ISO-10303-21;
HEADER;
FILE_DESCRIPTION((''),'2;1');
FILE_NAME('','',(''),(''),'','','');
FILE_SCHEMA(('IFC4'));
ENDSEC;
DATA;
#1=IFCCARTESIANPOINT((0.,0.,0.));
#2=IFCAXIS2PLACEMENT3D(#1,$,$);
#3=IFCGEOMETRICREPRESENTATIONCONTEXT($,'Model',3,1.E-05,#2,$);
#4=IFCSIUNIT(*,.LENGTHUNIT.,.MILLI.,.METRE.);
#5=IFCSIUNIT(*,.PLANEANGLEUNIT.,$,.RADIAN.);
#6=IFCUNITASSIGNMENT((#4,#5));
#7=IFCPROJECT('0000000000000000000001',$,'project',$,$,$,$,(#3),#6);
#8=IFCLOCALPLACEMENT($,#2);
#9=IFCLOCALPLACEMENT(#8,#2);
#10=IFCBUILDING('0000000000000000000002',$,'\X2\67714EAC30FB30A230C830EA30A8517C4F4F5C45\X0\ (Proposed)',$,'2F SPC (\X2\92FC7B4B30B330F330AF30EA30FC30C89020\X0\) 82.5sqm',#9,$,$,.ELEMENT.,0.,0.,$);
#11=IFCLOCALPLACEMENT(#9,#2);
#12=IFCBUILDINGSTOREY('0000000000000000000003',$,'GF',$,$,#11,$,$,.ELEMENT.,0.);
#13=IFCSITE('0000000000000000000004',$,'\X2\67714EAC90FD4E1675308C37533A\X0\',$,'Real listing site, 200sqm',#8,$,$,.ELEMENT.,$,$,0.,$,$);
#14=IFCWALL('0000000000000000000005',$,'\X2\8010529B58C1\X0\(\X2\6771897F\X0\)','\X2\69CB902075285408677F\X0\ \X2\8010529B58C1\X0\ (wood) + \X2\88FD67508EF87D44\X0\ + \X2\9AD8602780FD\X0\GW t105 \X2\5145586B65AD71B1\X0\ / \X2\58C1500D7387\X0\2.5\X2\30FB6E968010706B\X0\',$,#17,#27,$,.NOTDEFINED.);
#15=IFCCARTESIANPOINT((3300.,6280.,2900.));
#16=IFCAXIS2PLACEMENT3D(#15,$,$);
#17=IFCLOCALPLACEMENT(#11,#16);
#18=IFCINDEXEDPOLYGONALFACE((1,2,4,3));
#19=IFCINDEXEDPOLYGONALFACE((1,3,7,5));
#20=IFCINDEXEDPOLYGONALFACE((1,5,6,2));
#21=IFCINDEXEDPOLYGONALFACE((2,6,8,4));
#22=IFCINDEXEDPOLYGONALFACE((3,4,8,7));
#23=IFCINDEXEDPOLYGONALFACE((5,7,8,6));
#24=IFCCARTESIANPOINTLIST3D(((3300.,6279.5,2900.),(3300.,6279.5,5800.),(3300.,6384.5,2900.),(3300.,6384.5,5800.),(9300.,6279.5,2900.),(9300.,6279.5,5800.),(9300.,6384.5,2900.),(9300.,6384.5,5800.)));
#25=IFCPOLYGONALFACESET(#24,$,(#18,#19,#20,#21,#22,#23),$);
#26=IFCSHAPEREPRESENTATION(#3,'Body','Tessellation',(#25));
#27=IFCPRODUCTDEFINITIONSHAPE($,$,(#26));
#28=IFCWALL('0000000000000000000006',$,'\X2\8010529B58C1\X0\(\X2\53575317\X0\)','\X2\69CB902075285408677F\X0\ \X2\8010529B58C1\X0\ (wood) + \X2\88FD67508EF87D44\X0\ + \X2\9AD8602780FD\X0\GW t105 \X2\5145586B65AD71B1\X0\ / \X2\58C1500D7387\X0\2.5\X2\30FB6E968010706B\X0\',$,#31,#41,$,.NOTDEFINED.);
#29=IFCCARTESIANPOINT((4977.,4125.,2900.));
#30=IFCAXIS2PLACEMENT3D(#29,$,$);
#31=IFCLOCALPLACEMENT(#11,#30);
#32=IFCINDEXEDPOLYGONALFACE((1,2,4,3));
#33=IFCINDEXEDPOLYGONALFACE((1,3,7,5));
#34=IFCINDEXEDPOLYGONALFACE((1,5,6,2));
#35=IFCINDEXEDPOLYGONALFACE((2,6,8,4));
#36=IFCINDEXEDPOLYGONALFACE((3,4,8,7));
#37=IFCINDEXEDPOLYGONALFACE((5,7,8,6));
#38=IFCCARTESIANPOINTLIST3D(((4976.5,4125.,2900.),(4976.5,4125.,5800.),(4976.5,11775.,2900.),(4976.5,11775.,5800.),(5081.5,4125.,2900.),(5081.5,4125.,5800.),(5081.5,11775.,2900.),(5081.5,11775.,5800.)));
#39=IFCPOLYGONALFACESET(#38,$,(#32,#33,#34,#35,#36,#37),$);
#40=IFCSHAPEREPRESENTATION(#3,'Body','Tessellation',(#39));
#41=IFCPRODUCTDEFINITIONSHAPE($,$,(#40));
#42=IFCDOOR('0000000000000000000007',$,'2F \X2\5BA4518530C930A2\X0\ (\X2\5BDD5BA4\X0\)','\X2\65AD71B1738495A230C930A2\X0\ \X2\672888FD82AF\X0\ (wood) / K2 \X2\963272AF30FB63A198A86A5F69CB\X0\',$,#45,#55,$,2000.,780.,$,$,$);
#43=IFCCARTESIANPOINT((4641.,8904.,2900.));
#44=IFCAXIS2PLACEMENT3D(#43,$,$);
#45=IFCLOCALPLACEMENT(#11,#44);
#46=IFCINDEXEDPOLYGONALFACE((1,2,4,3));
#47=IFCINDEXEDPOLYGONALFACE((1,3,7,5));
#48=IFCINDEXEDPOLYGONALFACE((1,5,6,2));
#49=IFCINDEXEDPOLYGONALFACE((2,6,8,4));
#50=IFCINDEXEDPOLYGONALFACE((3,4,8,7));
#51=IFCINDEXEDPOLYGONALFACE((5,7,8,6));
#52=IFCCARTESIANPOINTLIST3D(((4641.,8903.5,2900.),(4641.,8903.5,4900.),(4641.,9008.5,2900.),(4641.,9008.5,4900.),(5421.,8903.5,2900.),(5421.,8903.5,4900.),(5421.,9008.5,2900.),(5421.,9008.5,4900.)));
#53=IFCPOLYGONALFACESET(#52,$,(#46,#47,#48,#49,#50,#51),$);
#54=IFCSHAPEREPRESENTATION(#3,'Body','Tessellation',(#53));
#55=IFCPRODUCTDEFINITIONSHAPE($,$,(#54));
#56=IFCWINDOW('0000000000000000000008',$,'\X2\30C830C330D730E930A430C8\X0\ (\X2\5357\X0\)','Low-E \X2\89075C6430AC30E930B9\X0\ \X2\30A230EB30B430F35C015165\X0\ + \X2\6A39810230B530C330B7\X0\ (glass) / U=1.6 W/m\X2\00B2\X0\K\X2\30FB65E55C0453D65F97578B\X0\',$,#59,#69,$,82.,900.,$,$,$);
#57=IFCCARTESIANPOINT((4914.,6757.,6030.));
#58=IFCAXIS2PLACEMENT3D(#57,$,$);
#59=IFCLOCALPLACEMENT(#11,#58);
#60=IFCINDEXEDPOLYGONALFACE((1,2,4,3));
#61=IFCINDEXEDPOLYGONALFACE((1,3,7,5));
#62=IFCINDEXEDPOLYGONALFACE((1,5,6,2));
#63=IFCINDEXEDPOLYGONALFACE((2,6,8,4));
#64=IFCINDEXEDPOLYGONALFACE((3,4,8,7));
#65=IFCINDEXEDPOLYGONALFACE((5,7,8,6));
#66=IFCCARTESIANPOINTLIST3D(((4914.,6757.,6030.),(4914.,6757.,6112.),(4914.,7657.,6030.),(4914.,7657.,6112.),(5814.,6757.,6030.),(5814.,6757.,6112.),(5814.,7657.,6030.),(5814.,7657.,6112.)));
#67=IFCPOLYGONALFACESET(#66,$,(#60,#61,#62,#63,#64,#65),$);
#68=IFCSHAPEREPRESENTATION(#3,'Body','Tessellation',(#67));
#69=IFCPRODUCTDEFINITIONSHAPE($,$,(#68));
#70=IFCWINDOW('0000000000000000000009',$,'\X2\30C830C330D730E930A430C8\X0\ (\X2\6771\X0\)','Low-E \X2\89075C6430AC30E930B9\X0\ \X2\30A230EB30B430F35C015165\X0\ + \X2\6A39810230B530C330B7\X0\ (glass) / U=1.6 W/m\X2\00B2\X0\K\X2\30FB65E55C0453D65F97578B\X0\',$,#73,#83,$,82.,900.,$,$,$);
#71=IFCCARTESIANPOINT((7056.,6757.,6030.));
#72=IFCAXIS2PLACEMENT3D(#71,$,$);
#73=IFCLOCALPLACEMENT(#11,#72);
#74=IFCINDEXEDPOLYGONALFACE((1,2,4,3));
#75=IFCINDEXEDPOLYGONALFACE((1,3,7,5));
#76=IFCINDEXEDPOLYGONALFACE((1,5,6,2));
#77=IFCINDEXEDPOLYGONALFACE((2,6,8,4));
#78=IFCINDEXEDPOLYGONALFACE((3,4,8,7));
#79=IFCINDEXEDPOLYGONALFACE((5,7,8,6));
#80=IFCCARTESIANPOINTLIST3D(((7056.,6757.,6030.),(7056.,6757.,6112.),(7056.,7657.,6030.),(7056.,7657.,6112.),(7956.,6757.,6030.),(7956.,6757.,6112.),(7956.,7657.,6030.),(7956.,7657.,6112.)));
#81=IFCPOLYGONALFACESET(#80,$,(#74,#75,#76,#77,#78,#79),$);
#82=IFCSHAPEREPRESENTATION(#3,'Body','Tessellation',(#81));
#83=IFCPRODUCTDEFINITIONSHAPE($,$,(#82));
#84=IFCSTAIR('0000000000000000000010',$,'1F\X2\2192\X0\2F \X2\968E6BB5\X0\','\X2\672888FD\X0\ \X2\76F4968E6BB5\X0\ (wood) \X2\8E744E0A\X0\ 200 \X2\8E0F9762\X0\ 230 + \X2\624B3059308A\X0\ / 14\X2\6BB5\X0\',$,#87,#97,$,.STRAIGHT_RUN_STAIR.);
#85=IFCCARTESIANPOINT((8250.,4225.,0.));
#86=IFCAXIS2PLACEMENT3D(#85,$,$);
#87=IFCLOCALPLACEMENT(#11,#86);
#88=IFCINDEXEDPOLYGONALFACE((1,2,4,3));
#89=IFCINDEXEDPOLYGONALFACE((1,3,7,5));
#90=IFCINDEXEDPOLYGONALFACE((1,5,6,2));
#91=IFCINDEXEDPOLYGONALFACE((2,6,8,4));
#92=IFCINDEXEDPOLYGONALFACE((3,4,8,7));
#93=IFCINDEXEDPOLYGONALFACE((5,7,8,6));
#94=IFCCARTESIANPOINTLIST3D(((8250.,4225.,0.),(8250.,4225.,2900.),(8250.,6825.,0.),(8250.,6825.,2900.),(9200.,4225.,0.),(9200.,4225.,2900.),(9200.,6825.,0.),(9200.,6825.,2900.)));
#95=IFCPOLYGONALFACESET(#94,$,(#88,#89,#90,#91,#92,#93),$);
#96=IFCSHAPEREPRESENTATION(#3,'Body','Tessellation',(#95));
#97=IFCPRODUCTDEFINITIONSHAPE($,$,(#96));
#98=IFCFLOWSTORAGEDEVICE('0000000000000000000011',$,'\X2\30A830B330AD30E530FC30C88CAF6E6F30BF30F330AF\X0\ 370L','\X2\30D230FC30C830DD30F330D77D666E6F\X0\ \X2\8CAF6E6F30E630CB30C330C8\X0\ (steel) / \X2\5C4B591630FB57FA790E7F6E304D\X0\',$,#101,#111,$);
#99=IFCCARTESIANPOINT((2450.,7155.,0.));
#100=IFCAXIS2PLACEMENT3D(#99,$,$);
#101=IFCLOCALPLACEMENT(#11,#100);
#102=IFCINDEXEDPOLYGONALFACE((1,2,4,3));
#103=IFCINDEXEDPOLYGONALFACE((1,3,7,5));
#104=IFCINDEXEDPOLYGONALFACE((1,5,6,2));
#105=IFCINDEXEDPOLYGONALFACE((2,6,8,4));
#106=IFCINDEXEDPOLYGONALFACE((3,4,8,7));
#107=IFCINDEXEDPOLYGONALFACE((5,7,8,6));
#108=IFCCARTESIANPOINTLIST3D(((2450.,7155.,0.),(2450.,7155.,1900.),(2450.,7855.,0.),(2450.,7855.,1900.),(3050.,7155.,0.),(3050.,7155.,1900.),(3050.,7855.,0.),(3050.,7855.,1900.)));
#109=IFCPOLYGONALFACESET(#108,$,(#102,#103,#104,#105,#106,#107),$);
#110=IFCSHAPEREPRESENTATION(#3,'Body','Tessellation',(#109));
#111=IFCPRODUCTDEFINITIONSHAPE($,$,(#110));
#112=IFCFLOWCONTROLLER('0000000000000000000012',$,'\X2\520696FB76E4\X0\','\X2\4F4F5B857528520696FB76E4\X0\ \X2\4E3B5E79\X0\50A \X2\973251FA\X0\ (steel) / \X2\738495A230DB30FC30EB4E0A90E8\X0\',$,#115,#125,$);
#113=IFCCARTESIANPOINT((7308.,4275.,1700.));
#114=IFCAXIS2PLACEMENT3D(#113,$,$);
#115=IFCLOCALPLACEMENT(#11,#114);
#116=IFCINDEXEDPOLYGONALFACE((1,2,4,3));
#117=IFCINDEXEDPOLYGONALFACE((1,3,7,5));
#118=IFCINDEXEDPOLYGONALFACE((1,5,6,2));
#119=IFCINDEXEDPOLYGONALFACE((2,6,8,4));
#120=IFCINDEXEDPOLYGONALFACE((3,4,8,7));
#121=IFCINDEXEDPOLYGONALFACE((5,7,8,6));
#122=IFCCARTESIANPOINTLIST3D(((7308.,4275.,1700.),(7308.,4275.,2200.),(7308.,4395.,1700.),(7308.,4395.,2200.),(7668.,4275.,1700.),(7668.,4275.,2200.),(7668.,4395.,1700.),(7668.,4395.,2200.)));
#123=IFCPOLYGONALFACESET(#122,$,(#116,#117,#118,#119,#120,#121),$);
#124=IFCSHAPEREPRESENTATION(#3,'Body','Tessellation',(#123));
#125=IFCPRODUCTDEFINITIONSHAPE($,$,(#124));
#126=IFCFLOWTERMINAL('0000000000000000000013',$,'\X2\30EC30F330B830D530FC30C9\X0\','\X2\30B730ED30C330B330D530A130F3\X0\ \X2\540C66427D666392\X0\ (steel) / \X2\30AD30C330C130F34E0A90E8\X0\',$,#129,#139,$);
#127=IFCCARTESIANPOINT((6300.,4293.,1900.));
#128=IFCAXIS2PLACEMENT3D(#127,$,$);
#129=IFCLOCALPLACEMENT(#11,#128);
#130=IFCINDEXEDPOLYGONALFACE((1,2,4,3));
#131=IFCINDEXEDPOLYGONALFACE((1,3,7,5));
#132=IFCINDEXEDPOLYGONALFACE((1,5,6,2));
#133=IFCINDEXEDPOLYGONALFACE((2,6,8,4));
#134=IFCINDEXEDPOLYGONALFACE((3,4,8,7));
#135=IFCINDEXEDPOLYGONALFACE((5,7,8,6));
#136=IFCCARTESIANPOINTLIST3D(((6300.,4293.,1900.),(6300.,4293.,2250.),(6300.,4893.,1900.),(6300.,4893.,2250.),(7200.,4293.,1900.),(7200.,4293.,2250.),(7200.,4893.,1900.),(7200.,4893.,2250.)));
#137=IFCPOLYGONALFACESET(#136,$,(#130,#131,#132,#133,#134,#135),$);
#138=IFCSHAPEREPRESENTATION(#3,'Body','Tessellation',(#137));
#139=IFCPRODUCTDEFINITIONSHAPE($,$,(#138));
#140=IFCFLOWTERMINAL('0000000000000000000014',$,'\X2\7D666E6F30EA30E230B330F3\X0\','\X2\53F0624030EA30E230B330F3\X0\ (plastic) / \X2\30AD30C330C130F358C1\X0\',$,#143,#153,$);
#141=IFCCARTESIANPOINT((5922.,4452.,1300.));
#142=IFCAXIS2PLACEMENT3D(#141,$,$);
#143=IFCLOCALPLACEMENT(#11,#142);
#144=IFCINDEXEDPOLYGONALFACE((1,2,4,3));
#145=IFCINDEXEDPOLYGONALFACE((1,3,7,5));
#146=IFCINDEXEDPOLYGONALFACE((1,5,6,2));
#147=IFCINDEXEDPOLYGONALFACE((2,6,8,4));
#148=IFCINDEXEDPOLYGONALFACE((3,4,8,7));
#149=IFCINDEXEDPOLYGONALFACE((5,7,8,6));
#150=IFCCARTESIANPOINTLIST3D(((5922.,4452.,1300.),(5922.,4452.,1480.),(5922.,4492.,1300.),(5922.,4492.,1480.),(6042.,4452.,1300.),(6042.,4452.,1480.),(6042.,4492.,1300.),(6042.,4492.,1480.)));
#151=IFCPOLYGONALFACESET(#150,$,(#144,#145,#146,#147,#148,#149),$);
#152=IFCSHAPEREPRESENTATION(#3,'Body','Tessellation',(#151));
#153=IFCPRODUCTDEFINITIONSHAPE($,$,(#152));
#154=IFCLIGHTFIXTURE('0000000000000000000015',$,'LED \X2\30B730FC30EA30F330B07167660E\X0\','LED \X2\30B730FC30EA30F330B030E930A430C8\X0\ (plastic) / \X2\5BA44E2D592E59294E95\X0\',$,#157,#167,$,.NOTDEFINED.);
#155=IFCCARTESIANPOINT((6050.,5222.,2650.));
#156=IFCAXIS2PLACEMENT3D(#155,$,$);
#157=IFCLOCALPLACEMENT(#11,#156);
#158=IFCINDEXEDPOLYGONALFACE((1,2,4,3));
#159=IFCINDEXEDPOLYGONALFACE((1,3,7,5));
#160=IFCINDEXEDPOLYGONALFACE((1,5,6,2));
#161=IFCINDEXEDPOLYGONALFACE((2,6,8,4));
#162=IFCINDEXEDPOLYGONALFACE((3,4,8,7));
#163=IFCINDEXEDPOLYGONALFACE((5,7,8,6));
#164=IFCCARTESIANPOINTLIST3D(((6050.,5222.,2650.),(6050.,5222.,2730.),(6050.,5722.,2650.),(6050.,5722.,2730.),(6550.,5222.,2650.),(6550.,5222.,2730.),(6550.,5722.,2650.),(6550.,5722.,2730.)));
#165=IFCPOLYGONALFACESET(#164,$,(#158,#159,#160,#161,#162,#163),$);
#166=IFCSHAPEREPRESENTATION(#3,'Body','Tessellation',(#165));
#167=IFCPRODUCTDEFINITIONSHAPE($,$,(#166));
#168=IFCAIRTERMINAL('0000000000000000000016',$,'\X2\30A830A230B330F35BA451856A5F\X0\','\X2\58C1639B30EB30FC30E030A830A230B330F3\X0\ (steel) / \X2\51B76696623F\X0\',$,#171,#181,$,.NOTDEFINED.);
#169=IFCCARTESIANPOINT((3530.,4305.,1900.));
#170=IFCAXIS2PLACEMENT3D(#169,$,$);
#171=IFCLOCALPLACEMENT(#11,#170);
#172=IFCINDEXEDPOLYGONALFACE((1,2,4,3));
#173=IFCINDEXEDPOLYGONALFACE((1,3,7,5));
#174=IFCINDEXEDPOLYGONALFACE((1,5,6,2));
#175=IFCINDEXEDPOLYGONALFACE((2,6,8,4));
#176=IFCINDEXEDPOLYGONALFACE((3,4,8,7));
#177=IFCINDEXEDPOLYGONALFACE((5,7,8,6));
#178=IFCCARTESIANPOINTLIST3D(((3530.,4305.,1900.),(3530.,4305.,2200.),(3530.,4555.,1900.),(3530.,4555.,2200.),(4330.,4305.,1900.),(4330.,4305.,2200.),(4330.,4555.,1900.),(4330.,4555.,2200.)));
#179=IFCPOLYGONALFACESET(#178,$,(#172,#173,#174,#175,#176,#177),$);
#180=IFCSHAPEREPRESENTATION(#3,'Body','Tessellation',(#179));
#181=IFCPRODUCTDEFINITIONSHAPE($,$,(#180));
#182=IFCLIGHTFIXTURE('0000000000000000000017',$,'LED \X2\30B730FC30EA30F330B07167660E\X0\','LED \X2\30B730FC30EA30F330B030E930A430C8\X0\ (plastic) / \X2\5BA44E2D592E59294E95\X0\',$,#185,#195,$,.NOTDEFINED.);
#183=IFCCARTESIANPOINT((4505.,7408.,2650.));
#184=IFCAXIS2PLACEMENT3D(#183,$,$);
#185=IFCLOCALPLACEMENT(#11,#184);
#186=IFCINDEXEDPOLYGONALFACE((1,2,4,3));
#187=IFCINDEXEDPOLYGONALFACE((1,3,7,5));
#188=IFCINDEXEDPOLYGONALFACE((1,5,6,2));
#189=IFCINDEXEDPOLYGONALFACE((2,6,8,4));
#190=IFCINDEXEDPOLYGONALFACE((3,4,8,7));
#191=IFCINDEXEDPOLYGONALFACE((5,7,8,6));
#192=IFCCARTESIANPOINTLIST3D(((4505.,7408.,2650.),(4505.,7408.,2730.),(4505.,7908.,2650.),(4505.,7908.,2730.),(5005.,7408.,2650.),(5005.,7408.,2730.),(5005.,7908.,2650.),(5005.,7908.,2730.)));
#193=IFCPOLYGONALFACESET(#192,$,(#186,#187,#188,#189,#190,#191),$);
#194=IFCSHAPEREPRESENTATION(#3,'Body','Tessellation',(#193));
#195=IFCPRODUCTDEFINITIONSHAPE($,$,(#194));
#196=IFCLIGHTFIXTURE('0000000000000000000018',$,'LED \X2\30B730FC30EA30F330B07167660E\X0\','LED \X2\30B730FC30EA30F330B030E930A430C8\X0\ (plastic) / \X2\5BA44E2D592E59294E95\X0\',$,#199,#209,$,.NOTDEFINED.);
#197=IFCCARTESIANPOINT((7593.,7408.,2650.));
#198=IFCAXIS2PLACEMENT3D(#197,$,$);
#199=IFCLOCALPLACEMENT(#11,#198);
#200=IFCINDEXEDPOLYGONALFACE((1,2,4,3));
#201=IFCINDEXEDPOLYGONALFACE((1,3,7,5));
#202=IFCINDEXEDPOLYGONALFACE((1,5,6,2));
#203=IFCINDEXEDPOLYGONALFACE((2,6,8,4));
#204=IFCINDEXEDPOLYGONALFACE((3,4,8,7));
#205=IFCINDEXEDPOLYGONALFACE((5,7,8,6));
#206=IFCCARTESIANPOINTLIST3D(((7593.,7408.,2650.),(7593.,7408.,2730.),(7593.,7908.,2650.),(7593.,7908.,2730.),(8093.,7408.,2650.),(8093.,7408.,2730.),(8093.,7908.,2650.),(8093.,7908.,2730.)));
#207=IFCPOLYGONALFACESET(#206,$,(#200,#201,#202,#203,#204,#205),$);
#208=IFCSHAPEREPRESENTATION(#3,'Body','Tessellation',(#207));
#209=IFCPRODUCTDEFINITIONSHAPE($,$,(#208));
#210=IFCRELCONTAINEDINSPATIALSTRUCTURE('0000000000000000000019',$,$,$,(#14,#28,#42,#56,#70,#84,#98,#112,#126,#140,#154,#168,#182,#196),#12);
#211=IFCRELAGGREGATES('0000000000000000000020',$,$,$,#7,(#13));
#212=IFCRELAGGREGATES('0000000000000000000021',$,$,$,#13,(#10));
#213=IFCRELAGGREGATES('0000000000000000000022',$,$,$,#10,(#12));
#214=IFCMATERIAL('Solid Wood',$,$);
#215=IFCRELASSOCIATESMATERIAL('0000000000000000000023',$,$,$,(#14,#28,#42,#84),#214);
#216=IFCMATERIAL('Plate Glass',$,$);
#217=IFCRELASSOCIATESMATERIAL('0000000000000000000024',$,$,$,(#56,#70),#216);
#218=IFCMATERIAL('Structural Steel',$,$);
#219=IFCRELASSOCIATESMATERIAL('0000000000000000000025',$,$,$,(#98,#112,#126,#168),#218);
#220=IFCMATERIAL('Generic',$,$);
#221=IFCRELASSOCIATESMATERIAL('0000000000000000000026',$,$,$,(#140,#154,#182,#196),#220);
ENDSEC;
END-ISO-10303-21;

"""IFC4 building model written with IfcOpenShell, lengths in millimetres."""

from ifc_helpers import new_model, si_unit, frame, frame_2d, origin, place, context, project, spatial, rectangle, extrude, material, element, fill, save


model = new_model("IFC4")

# Units and contexts
model_context = context("Model", 3, precision=1e-05, world=origin())
ifc_project = project(units=[si_unit("LENGTHUNIT", "METRE", prefix="MILLI"), si_unit("PLANEANGLEUNIT", "RADIAN")], contexts=[model_context])

# Site, building, storey
site_placement = place(None, origin())
site = spatial("IfcSite", under=ifc_project, at=site_placement, Name="東京都世田谷区", ObjectType="Real listing site, 200sqm", CompositionType="ELEMENT", RefElevation=0.0)
building_placement = place(site_placement, origin())
building = spatial("IfcBuilding", under=site, at=building_placement, Name="東京・アトリエ兼住居 (Proposed)", ObjectType="2F SPC (鋼筋コンクリート造) 82.5sqm", CompositionType="ELEMENT", ElevationOfRefHeight=0.0, ElevationOfTerrain=0.0)
storey_placement = place(building_placement, origin())
storey = spatial("IfcBuildingStorey", under=building, at=storey_placement, Name="GF", CompositionType="ELEMENT", Elevation=0.0)

# Shared definitions
ifc_material_1 = material(Name="Solid Wood")

# Wall
wall_1_placement = place(storey_placement, frame((3300.0, 6280.0, 2900.0)))
element("IfcWall", 1, at=wall_1_placement, inside=storey, material=ifc_material_1, Name="耐力壁(東西)", Description="構造用合板 耐力壁 (wood) + 製材軸組 + 高性能GW t105 充填断熱 / 壁倍率2.5・準耐火", PredefinedType="NOTDEFINED", context=model_context, shape_type="SweptSolid", body=[
    extrude(rectangle(XDim=6000.0, YDim=105.0, at=frame_2d((3000.0, 52.0))), frame((3300.0, 6280.0, 2900.0)), (0.0, 0.0, 1.0), 2900.0),
])

# Wall, opening, door
wall_2_placement = place(storey_placement, frame((4977.0, 4125.0, 2900.0)))
wall_2 = element("IfcWall", 2, at=wall_2_placement, inside=storey, material=ifc_material_1, Name="耐力壁(南北)", Description="構造用合板 耐力壁 (wood) + 製材軸組 + 高性能GW t105 充填断熱 / 壁倍率2.5・準耐火", PredefinedType="NOTDEFINED", context=model_context, shape_type="SweptSolid", body=[
    extrude(rectangle(XDim=105.0, YDim=7650.0, at=frame_2d((52.0, 3825.0))), frame((4977.0, 4125.0, 2900.0)), (0.0, 0.0, 1.0), 2900.0),
])
opening_placement = place(storey_placement, frame((4641.0, 8904.0, 2900.0)))
opening = element("IfcOpeningElement", 3, at=opening_placement, cuts=wall_2, PredefinedType="NOTDEFINED", context=model_context, shape_type="SweptSolid", body=[
    extrude(rectangle(XDim=780.0, YDim=105.0, at=frame_2d((390.0, 52.0))), frame((4641.0, 8904.0, 2900.0)), (0.0, 0.0, 1.0), 2000.0),
])
door_placement = place(storey_placement, frame((4641.0, 8904.0, 2900.0)))
door = element("IfcDoor", 4, at=door_placement, inside=storey, material=ifc_material_1, Name="2F 室内ドア (寝室)", Description="断熱玄関ドア 木製芯 (wood) / K2 防犯・採風機構", OverallHeight=2000.0, OverallWidth=780.0, context=model_context, shape_type="SweptSolid", body=[
    extrude(rectangle(XDim=780.0, YDim=105.0, at=frame_2d((390.0, 52.0))), frame((4641.0, 8904.0, 2900.0)), (0.0, 0.0, 1.0), 2000.0),
])
fill(opening, door)

# Windows
ifc_material_2 = material(Name="Plate Glass")
window_1_placement = place(storey_placement, frame((4914.0, 6757.0, 6030.0)))
element("IfcWindow", 5, at=window_1_placement, inside=storey, material=ifc_material_2, Name="トップライト (南)", Description="Low-E 複層ガラス アルゴン封入 + 樹脂サッシ (glass) / U=1.6 W/m²K・日射取得型", OverallHeight=82.0, OverallWidth=900.0, context=model_context, shape_type="SweptSolid", body=[
    extrude(rectangle(XDim=900.0, YDim=900.0, at=frame_2d((450.0, 450.0))), frame((4914.0, 6757.0, 6030.0)), (0.0, 0.0, 1.0), 82.0),
])
window_2_placement = place(storey_placement, frame((7056.0, 6757.0, 6030.0)))
element("IfcWindow", 6, at=window_2_placement, inside=storey, material=ifc_material_2, Name="トップライト (東)", Description="Low-E 複層ガラス アルゴン封入 + 樹脂サッシ (glass) / U=1.6 W/m²K・日射取得型", OverallHeight=82.0, OverallWidth=900.0, context=model_context, shape_type="SweptSolid", body=[
    extrude(rectangle(XDim=900.0, YDim=900.0, at=frame_2d((450.0, 450.0))), frame((7056.0, 6757.0, 6030.0)), (0.0, 0.0, 1.0), 82.0),
])

# Stair
stair_placement = place(storey_placement, frame((8250.0, 4225.0, 0.0)))
element("IfcStair", 7, at=stair_placement, inside=storey, material=ifc_material_1, Name="1F→2F 階段", Description="木製 直階段 (wood) 蹴上 200 踏面 230 + 手すり / 14段", PredefinedType="STRAIGHT_RUN_STAIR", context=model_context, shape_type="SweptSolid", body=[
    extrude(rectangle(XDim=950.0, YDim=2600.0, at=frame_2d((475.0, 1300.0))), frame((8250.0, 4225.0, 0.0)), (0.0, 0.0, 1.0), 2900.0),
])

# Flow storage device
ifc_material_3 = material(Name="Structural Steel")
flow_storage_device_placement = place(storey_placement, frame((2450.0, 7155.0, 0.0)))
element("IfcFlowStorageDevice", 8, at=flow_storage_device_placement, inside=storey, material=ifc_material_3, Name="エコキュート貯湯タンク 370L", Description="ヒートポンプ給湯 貯湯ユニット (steel) / 屋外・基礎置き", context=model_context, shape_type="SweptSolid", body=[
    extrude(rectangle(XDim=600.0, YDim=700.0, at=frame_2d((300.0, 350.0))), frame((2450.0, 7155.0, 0.0)), (0.0, 0.0, 1.0), 1900.0),
])

# Flow controller
flow_controller_placement = place(storey_placement, frame((7308.0, 4275.0, 1700.0)))
element("IfcFlowController", 9, at=flow_controller_placement, inside=storey, material=ifc_material_3, Name="分電盤", Description="住宅用分電盤 主幹50A 露出 (steel) / 玄関ホール上部", context=model_context, shape_type="SweptSolid", body=[
    extrude(rectangle(XDim=360.0, YDim=120.0, at=frame_2d((180.0, 60.0))), frame((7308.0, 4275.0, 1700.0)), (0.0, 0.0, 1.0), 500.0),
])

# Flow terminals
flow_terminal_1_placement = place(storey_placement, frame((6300.0, 4293.0, 1900.0)))
element("IfcFlowTerminal", 10, at=flow_terminal_1_placement, inside=storey, material=ifc_material_3, Name="レンジフード", Description="シロッコファン 同時給排 (steel) / キッチン上部", context=model_context, shape_type="SweptSolid", body=[
    extrude(rectangle(XDim=900.0, YDim=600.0, at=frame_2d((450.0, 300.0))), frame((6300.0, 4293.0, 1900.0)), (0.0, 0.0, 1.0), 350.0),
])
ifc_material_4 = material(Name="Generic")
flow_terminal_2_placement = place(storey_placement, frame((5922.0, 4452.0, 1300.0)))
element("IfcFlowTerminal", 11, at=flow_terminal_2_placement, inside=storey, material=ifc_material_4, Name="給湯リモコン", Description="台所リモコン (plastic) / キッチン壁", context=model_context, shape_type="SweptSolid", body=[
    extrude(rectangle(XDim=120.0, YDim=40.0, at=frame_2d((60.0, 20.0))), frame((5922.0, 4452.0, 1300.0)), (0.0, 0.0, 1.0), 180.0),
])

# Light fixture
light_fixture_1_placement = place(storey_placement, frame((6050.0, 5222.0, 2650.0)))
element("IfcLightFixture", 12, at=light_fixture_1_placement, inside=storey, material=ifc_material_4, Name="LED シーリング照明", Description="LED シーリングライト (plastic) / 室中央天井", PredefinedType="NOTDEFINED", context=model_context, shape_type="SweptSolid", body=[
    extrude(rectangle(XDim=500.0, YDim=500.0, at=frame_2d((250.0, 250.0))), frame((6050.0, 5222.0, 2650.0)), (0.0, 0.0, 1.0), 80.0),
])

# Air terminal
air_terminal_1_placement = place(storey_placement, frame((3530.0, 4305.0, 1900.0)))
element("IfcAirTerminal", 13, at=air_terminal_1_placement, inside=storey, material=ifc_material_3, Name="エアコン室内機", Description="壁掛ルームエアコン (steel) / 冷暖房", PredefinedType="NOTDEFINED", context=model_context, shape_type="SweptSolid", body=[
    extrude(rectangle(XDim=800.0, YDim=250.0, at=frame_2d((400.0, 125.0))), frame((3530.0, 4305.0, 1900.0)), (0.0, 0.0, 1.0), 300.0),
])

# Light fixtures
light_fixture_2_placement = place(storey_placement, frame((4505.0, 7408.0, 2650.0)))
element("IfcLightFixture", 14, at=light_fixture_2_placement, inside=storey, material=ifc_material_4, Name="LED シーリング照明", Description="LED シーリングライト (plastic) / 室中央天井", PredefinedType="NOTDEFINED", context=model_context, shape_type="SweptSolid", body=[
    extrude(rectangle(XDim=500.0, YDim=500.0, at=frame_2d((250.0, 250.0))), frame((4505.0, 7408.0, 2650.0)), (0.0, 0.0, 1.0), 80.0),
])
light_fixture_3_placement = place(storey_placement, frame((7593.0, 7408.0, 2650.0)))
element("IfcLightFixture", 15, at=light_fixture_3_placement, inside=storey, material=ifc_material_4, Name="LED シーリング照明", Description="LED シーリングライト (plastic) / 室中央天井", PredefinedType="NOTDEFINED", context=model_context, shape_type="SweptSolid", body=[
    extrude(rectangle(XDim=500.0, YDim=500.0, at=frame_2d((250.0, 250.0))), frame((7593.0, 7408.0, 2650.0)), (0.0, 0.0, 1.0), 80.0),
])

save(model, "model.ifc")
